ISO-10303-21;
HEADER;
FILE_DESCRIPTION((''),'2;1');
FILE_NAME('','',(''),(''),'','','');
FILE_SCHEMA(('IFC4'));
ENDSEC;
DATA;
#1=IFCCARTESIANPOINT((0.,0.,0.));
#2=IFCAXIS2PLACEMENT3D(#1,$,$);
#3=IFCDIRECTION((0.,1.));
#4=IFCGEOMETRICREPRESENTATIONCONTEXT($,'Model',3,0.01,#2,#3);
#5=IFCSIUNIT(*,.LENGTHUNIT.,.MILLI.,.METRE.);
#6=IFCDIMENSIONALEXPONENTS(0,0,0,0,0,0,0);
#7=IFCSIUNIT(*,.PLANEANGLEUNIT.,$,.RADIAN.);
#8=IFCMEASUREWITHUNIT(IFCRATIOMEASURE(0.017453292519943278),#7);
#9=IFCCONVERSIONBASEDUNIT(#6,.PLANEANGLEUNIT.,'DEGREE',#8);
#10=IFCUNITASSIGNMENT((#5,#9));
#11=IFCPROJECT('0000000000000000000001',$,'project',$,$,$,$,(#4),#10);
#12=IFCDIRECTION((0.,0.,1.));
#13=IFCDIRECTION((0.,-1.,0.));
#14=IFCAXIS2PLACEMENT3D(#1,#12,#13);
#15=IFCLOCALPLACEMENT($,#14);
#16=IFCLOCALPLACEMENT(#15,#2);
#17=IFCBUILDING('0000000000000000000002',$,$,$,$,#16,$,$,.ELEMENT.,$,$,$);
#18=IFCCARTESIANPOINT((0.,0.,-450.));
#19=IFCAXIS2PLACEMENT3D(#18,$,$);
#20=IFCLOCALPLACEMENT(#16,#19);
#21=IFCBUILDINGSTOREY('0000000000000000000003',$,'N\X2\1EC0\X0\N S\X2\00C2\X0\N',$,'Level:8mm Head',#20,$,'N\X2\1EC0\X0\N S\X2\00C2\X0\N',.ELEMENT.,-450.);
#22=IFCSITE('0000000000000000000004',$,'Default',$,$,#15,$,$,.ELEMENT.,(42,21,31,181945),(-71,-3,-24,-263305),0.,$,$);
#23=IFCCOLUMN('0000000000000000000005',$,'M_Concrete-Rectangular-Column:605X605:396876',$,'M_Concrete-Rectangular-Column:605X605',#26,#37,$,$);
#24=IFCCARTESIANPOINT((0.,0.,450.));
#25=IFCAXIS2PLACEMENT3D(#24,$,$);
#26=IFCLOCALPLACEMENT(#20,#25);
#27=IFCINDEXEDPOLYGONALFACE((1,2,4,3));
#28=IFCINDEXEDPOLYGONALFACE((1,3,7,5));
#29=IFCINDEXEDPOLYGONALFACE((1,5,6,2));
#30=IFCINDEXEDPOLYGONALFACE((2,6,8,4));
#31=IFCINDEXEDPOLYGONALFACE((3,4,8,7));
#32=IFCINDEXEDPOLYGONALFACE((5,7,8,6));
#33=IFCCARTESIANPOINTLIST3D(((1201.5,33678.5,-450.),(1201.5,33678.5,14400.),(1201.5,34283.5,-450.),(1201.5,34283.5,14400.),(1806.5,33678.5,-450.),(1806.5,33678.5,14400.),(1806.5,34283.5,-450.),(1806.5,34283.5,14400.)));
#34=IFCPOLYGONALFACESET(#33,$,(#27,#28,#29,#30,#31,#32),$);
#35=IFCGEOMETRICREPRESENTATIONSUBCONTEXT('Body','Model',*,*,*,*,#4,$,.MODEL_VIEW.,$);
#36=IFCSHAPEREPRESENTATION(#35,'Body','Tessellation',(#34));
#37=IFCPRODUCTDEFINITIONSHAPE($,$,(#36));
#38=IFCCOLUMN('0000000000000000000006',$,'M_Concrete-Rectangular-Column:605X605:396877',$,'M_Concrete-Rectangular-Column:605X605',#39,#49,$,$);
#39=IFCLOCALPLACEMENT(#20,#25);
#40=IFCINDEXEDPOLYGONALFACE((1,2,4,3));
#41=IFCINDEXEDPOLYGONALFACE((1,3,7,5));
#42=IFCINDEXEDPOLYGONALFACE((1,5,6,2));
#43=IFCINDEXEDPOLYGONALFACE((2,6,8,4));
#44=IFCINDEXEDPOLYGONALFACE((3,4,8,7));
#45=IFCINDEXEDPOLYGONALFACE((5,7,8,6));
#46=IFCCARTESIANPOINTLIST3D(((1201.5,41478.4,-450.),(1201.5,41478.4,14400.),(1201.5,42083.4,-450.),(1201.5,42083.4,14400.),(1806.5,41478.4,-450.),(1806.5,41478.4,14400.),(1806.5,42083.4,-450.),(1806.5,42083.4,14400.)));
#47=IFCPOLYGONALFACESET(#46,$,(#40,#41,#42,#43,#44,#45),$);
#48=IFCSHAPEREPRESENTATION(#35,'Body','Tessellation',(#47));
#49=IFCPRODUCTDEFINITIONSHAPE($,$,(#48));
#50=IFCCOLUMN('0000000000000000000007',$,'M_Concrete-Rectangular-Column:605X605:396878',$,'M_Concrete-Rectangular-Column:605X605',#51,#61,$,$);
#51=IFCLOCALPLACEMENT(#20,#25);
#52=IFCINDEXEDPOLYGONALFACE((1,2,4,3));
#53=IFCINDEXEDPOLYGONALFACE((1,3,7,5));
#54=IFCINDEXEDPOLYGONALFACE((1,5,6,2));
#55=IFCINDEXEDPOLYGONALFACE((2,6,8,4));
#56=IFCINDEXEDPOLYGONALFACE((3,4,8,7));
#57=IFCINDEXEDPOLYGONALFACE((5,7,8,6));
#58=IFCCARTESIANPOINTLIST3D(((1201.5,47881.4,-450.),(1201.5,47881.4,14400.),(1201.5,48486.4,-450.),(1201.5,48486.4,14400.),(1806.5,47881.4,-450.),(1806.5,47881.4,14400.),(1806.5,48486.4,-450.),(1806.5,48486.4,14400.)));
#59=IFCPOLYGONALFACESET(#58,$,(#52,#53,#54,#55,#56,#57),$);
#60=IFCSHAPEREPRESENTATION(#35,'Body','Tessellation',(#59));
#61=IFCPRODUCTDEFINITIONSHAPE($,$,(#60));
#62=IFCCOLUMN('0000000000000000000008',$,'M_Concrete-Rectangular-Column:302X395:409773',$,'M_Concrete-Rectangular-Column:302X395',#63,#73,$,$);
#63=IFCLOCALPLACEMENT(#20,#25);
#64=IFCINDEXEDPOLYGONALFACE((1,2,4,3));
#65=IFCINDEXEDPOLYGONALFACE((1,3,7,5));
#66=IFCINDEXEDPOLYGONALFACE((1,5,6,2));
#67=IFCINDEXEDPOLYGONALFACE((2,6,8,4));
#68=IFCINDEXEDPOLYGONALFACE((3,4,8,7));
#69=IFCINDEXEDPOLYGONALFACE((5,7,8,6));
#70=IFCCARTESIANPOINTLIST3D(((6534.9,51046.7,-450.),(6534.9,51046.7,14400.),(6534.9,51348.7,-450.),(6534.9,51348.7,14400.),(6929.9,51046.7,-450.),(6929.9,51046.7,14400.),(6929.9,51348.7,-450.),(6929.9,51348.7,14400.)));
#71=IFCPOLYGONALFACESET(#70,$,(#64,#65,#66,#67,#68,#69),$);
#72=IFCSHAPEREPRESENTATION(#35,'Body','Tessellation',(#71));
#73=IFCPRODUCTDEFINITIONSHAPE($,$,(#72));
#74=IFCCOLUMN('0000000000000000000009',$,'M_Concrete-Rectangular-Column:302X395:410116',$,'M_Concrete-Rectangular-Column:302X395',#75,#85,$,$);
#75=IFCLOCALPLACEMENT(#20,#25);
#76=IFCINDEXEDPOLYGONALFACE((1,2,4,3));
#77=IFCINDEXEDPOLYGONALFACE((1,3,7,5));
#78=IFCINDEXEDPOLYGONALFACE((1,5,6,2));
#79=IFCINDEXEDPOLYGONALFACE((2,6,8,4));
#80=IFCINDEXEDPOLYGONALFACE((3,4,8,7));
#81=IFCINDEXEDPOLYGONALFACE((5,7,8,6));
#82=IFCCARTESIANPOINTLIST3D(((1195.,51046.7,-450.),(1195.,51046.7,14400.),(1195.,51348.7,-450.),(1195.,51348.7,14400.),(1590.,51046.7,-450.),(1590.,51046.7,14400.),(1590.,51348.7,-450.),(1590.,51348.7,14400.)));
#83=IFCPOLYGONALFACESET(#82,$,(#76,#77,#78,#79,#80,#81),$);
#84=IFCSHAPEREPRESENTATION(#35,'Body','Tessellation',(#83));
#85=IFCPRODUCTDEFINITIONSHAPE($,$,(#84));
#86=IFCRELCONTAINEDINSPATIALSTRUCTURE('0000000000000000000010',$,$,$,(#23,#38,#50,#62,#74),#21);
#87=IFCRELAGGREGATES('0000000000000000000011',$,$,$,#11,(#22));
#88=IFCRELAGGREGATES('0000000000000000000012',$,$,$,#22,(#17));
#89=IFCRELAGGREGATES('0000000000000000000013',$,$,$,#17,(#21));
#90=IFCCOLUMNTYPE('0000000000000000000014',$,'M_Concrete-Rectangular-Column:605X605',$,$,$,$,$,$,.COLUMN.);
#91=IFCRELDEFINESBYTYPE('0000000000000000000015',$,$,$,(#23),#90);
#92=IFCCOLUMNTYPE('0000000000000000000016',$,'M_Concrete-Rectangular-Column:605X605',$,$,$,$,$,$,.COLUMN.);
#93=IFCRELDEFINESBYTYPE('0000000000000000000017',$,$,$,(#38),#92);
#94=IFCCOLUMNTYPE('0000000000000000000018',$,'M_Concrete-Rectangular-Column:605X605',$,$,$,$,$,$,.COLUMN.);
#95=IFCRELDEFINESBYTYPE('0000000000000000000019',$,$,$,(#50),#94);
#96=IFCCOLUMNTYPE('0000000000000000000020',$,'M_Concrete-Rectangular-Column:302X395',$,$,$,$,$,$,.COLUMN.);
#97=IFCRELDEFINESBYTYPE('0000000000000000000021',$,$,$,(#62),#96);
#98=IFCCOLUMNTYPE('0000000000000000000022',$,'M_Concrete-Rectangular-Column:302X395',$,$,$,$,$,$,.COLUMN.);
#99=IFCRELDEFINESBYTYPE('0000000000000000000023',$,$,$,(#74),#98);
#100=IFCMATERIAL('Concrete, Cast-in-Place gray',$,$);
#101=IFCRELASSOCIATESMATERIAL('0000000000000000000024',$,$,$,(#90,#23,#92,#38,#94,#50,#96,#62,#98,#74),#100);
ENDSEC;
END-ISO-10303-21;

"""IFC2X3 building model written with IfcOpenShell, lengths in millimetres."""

from ifc_helpers import new_model, entity, si_unit, converted_unit, direction, frame, frame_2d, origin, origin_2d_with_axis, place, context, subcontext, project, spatial, rectangle, extrude, source, transform, mapped, material, type_object, type_shapes, element, save


model = new_model("IFC2X3")

# Units and contexts
model_context = context("Model", 3, precision=0.01, world=origin(), true_north=direction((0.0, 1.0)))
body_context = subcontext(model_context, "Body", "Model", "MODEL_VIEW")
ifc_project = project(units=[si_unit("LENGTHUNIT", "METRE", prefix="MILLI"), converted_unit("PLANEANGLEUNIT", "DEGREE", entity("IfcRatioMeasure", 0.017453292519943278), si_unit("PLANEANGLEUNIT", "RADIAN"), dimensions=[0, 0, 0, 0, 0, 0, 0])], contexts=[model_context])

# Site, building, storey
site_placement = place(None, frame((0.0, 0.0, 0.0), z_axis=(0.0, 0.0, 1.0), x_axis=(0.0, -1.0, 0.0)))
site = spatial("IfcSite", under=ifc_project, at=site_placement, Name="Default", CompositionType="ELEMENT", RefLatitude=(42, 21, 31, 181945), RefLongitude=(-71, -3, -24, -263305), RefElevation=0.0)
building_placement = place(site_placement, origin())
building = spatial("IfcBuilding", under=site, at=building_placement, CompositionType="ELEMENT")
storey_placement = place(building_placement, frame((0.0, 0.0, -450.0)))
storey = spatial("IfcBuildingStorey", under=building, at=storey_placement, Name="NỀN SÂN", ObjectType="Level:8mm Head", LongName="NỀN SÂN", CompositionType="ELEMENT", Elevation=-450.0)

# Columns
ifc_material_1 = material(Name="Concrete, Cast-in-Place gray")
column_type_1 = type_object("IfcColumnType", Name="M_Concrete-Rectangular-Column:605X605", PredefinedType="COLUMN", material=ifc_material_1)
shared_shape_1 = source(origin(), body_context, "Body", "SweptSolid", [
    extrude(rectangle(XDim=605.0, YDim=605.0, at=origin_2d_with_axis()), frame((1504.0, 33981.0, -450.0), z_axis=(0.0, 0.0, 1.0), x_axis=(0.0, -1.0, 0.0)), (0.0, 0.0, 1.0), 14850.0),
])
type_shapes(column_type_1, [shared_shape_1])
column_1_placement = place(storey_placement, frame((0.0, 0.0, 450.0)))
element("IfcColumn", 1, at=column_1_placement, inside=storey, type_object=column_type_1, material=ifc_material_1, Name="M_Concrete-Rectangular-Column:605X605:396876", ObjectType="M_Concrete-Rectangular-Column:605X605", context=body_context, shape_type="MappedRepresentation", body=[
    mapped(shared_shape_1, transform((0.0, 0.0, 0.0), scale=1.0)),
])
column_type_2 = type_object("IfcColumnType", Name="M_Concrete-Rectangular-Column:605X605", PredefinedType="COLUMN", material=ifc_material_1)
shared_shape_2 = source(origin(), body_context, "Body", "SweptSolid", [
    extrude(rectangle(XDim=605.0, YDim=605.0, at=origin_2d_with_axis()), frame((1504.0, 41780.9, -450.0), z_axis=(0.0, 0.0, 1.0), x_axis=(0.0, -1.0, 0.0)), (0.0, 0.0, 1.0), 14850.0),
])
type_shapes(column_type_2, [shared_shape_2])
column_2_placement = place(storey_placement, frame((0.0, 0.0, 450.0)))
element("IfcColumn", 2, at=column_2_placement, inside=storey, type_object=column_type_2, material=ifc_material_1, Name="M_Concrete-Rectangular-Column:605X605:396877", ObjectType="M_Concrete-Rectangular-Column:605X605", context=body_context, shape_type="MappedRepresentation", body=[
    mapped(shared_shape_2, transform((0.0, 0.0, 0.0), scale=1.0)),
])
column_type_3 = type_object("IfcColumnType", Name="M_Concrete-Rectangular-Column:605X605", PredefinedType="COLUMN", material=ifc_material_1)
shared_shape_3 = source(origin(), body_context, "Body", "SweptSolid", [
    extrude(rectangle(XDim=605.0, YDim=605.0, at=origin_2d_with_axis()), frame((1504.0, 48183.9, -450.0), z_axis=(0.0, 0.0, 1.0), x_axis=(0.0, -1.0, 0.0)), (0.0, 0.0, 1.0), 14850.0),
])
type_shapes(column_type_3, [shared_shape_3])
column_3_placement = place(storey_placement, frame((0.0, 0.0, 450.0)))
element("IfcColumn", 3, at=column_3_placement, inside=storey, type_object=column_type_3, material=ifc_material_1, Name="M_Concrete-Rectangular-Column:605X605:396878", ObjectType="M_Concrete-Rectangular-Column:605X605", context=body_context, shape_type="MappedRepresentation", body=[
    mapped(shared_shape_3, transform((0.0, 0.0, 0.0), scale=1.0)),
])
column_type_4 = type_object("IfcColumnType", Name="M_Concrete-Rectangular-Column:302X395", PredefinedType="COLUMN", material=ifc_material_1)
shared_shape_4 = source(origin(), body_context, "Body", "SweptSolid", [
    extrude(rectangle(XDim=302.0, YDim=395.0, at=frame_2d((0.0, 0.0), x_axis=(1.0, 0.0))), frame((6732.4, 51197.7, -450.0), z_axis=(0.0, 0.0, 1.0), x_axis=(0.0, -1.0, 0.0)), (0.0, 0.0, 1.0), 14850.0),
])
type_shapes(column_type_4, [shared_shape_4])
column_4_placement = place(storey_placement, frame((0.0, 0.0, 450.0)))
element("IfcColumn", 4, at=column_4_placement, inside=storey, type_object=column_type_4, material=ifc_material_1, Name="M_Concrete-Rectangular-Column:302X395:409773", ObjectType="M_Concrete-Rectangular-Column:302X395", context=body_context, shape_type="MappedRepresentation", body=[
    mapped(shared_shape_4, transform((0.0, 0.0, 0.0), scale=1.0)),
])
column_type_5 = type_object("IfcColumnType", Name="M_Concrete-Rectangular-Column:302X395", PredefinedType="COLUMN", material=ifc_material_1)
shared_shape_5 = source(origin(), body_context, "Body", "SweptSolid", [
    extrude(rectangle(XDim=302.0, YDim=395.0, at=frame_2d((0.0, 0.0), x_axis=(1.0, 0.0))), frame((1392.5, 51197.7, -450.0), z_axis=(0.0, 0.0, 1.0), x_axis=(0.0, -1.0, 0.0)), (0.0, 0.0, 1.0), 14850.0),
])
type_shapes(column_type_5, [shared_shape_5])
column_5_placement = place(storey_placement, frame((0.0, 0.0, 450.0)))
element("IfcColumn", 5, at=column_5_placement, inside=storey, type_object=column_type_5, material=ifc_material_1, Name="M_Concrete-Rectangular-Column:302X395:410116", ObjectType="M_Concrete-Rectangular-Column:302X395", context=body_context, shape_type="MappedRepresentation", body=[
    mapped(shared_shape_5, transform((0.0, 0.0, 0.0), scale=1.0)),
])

save(model, "model.ifc")
